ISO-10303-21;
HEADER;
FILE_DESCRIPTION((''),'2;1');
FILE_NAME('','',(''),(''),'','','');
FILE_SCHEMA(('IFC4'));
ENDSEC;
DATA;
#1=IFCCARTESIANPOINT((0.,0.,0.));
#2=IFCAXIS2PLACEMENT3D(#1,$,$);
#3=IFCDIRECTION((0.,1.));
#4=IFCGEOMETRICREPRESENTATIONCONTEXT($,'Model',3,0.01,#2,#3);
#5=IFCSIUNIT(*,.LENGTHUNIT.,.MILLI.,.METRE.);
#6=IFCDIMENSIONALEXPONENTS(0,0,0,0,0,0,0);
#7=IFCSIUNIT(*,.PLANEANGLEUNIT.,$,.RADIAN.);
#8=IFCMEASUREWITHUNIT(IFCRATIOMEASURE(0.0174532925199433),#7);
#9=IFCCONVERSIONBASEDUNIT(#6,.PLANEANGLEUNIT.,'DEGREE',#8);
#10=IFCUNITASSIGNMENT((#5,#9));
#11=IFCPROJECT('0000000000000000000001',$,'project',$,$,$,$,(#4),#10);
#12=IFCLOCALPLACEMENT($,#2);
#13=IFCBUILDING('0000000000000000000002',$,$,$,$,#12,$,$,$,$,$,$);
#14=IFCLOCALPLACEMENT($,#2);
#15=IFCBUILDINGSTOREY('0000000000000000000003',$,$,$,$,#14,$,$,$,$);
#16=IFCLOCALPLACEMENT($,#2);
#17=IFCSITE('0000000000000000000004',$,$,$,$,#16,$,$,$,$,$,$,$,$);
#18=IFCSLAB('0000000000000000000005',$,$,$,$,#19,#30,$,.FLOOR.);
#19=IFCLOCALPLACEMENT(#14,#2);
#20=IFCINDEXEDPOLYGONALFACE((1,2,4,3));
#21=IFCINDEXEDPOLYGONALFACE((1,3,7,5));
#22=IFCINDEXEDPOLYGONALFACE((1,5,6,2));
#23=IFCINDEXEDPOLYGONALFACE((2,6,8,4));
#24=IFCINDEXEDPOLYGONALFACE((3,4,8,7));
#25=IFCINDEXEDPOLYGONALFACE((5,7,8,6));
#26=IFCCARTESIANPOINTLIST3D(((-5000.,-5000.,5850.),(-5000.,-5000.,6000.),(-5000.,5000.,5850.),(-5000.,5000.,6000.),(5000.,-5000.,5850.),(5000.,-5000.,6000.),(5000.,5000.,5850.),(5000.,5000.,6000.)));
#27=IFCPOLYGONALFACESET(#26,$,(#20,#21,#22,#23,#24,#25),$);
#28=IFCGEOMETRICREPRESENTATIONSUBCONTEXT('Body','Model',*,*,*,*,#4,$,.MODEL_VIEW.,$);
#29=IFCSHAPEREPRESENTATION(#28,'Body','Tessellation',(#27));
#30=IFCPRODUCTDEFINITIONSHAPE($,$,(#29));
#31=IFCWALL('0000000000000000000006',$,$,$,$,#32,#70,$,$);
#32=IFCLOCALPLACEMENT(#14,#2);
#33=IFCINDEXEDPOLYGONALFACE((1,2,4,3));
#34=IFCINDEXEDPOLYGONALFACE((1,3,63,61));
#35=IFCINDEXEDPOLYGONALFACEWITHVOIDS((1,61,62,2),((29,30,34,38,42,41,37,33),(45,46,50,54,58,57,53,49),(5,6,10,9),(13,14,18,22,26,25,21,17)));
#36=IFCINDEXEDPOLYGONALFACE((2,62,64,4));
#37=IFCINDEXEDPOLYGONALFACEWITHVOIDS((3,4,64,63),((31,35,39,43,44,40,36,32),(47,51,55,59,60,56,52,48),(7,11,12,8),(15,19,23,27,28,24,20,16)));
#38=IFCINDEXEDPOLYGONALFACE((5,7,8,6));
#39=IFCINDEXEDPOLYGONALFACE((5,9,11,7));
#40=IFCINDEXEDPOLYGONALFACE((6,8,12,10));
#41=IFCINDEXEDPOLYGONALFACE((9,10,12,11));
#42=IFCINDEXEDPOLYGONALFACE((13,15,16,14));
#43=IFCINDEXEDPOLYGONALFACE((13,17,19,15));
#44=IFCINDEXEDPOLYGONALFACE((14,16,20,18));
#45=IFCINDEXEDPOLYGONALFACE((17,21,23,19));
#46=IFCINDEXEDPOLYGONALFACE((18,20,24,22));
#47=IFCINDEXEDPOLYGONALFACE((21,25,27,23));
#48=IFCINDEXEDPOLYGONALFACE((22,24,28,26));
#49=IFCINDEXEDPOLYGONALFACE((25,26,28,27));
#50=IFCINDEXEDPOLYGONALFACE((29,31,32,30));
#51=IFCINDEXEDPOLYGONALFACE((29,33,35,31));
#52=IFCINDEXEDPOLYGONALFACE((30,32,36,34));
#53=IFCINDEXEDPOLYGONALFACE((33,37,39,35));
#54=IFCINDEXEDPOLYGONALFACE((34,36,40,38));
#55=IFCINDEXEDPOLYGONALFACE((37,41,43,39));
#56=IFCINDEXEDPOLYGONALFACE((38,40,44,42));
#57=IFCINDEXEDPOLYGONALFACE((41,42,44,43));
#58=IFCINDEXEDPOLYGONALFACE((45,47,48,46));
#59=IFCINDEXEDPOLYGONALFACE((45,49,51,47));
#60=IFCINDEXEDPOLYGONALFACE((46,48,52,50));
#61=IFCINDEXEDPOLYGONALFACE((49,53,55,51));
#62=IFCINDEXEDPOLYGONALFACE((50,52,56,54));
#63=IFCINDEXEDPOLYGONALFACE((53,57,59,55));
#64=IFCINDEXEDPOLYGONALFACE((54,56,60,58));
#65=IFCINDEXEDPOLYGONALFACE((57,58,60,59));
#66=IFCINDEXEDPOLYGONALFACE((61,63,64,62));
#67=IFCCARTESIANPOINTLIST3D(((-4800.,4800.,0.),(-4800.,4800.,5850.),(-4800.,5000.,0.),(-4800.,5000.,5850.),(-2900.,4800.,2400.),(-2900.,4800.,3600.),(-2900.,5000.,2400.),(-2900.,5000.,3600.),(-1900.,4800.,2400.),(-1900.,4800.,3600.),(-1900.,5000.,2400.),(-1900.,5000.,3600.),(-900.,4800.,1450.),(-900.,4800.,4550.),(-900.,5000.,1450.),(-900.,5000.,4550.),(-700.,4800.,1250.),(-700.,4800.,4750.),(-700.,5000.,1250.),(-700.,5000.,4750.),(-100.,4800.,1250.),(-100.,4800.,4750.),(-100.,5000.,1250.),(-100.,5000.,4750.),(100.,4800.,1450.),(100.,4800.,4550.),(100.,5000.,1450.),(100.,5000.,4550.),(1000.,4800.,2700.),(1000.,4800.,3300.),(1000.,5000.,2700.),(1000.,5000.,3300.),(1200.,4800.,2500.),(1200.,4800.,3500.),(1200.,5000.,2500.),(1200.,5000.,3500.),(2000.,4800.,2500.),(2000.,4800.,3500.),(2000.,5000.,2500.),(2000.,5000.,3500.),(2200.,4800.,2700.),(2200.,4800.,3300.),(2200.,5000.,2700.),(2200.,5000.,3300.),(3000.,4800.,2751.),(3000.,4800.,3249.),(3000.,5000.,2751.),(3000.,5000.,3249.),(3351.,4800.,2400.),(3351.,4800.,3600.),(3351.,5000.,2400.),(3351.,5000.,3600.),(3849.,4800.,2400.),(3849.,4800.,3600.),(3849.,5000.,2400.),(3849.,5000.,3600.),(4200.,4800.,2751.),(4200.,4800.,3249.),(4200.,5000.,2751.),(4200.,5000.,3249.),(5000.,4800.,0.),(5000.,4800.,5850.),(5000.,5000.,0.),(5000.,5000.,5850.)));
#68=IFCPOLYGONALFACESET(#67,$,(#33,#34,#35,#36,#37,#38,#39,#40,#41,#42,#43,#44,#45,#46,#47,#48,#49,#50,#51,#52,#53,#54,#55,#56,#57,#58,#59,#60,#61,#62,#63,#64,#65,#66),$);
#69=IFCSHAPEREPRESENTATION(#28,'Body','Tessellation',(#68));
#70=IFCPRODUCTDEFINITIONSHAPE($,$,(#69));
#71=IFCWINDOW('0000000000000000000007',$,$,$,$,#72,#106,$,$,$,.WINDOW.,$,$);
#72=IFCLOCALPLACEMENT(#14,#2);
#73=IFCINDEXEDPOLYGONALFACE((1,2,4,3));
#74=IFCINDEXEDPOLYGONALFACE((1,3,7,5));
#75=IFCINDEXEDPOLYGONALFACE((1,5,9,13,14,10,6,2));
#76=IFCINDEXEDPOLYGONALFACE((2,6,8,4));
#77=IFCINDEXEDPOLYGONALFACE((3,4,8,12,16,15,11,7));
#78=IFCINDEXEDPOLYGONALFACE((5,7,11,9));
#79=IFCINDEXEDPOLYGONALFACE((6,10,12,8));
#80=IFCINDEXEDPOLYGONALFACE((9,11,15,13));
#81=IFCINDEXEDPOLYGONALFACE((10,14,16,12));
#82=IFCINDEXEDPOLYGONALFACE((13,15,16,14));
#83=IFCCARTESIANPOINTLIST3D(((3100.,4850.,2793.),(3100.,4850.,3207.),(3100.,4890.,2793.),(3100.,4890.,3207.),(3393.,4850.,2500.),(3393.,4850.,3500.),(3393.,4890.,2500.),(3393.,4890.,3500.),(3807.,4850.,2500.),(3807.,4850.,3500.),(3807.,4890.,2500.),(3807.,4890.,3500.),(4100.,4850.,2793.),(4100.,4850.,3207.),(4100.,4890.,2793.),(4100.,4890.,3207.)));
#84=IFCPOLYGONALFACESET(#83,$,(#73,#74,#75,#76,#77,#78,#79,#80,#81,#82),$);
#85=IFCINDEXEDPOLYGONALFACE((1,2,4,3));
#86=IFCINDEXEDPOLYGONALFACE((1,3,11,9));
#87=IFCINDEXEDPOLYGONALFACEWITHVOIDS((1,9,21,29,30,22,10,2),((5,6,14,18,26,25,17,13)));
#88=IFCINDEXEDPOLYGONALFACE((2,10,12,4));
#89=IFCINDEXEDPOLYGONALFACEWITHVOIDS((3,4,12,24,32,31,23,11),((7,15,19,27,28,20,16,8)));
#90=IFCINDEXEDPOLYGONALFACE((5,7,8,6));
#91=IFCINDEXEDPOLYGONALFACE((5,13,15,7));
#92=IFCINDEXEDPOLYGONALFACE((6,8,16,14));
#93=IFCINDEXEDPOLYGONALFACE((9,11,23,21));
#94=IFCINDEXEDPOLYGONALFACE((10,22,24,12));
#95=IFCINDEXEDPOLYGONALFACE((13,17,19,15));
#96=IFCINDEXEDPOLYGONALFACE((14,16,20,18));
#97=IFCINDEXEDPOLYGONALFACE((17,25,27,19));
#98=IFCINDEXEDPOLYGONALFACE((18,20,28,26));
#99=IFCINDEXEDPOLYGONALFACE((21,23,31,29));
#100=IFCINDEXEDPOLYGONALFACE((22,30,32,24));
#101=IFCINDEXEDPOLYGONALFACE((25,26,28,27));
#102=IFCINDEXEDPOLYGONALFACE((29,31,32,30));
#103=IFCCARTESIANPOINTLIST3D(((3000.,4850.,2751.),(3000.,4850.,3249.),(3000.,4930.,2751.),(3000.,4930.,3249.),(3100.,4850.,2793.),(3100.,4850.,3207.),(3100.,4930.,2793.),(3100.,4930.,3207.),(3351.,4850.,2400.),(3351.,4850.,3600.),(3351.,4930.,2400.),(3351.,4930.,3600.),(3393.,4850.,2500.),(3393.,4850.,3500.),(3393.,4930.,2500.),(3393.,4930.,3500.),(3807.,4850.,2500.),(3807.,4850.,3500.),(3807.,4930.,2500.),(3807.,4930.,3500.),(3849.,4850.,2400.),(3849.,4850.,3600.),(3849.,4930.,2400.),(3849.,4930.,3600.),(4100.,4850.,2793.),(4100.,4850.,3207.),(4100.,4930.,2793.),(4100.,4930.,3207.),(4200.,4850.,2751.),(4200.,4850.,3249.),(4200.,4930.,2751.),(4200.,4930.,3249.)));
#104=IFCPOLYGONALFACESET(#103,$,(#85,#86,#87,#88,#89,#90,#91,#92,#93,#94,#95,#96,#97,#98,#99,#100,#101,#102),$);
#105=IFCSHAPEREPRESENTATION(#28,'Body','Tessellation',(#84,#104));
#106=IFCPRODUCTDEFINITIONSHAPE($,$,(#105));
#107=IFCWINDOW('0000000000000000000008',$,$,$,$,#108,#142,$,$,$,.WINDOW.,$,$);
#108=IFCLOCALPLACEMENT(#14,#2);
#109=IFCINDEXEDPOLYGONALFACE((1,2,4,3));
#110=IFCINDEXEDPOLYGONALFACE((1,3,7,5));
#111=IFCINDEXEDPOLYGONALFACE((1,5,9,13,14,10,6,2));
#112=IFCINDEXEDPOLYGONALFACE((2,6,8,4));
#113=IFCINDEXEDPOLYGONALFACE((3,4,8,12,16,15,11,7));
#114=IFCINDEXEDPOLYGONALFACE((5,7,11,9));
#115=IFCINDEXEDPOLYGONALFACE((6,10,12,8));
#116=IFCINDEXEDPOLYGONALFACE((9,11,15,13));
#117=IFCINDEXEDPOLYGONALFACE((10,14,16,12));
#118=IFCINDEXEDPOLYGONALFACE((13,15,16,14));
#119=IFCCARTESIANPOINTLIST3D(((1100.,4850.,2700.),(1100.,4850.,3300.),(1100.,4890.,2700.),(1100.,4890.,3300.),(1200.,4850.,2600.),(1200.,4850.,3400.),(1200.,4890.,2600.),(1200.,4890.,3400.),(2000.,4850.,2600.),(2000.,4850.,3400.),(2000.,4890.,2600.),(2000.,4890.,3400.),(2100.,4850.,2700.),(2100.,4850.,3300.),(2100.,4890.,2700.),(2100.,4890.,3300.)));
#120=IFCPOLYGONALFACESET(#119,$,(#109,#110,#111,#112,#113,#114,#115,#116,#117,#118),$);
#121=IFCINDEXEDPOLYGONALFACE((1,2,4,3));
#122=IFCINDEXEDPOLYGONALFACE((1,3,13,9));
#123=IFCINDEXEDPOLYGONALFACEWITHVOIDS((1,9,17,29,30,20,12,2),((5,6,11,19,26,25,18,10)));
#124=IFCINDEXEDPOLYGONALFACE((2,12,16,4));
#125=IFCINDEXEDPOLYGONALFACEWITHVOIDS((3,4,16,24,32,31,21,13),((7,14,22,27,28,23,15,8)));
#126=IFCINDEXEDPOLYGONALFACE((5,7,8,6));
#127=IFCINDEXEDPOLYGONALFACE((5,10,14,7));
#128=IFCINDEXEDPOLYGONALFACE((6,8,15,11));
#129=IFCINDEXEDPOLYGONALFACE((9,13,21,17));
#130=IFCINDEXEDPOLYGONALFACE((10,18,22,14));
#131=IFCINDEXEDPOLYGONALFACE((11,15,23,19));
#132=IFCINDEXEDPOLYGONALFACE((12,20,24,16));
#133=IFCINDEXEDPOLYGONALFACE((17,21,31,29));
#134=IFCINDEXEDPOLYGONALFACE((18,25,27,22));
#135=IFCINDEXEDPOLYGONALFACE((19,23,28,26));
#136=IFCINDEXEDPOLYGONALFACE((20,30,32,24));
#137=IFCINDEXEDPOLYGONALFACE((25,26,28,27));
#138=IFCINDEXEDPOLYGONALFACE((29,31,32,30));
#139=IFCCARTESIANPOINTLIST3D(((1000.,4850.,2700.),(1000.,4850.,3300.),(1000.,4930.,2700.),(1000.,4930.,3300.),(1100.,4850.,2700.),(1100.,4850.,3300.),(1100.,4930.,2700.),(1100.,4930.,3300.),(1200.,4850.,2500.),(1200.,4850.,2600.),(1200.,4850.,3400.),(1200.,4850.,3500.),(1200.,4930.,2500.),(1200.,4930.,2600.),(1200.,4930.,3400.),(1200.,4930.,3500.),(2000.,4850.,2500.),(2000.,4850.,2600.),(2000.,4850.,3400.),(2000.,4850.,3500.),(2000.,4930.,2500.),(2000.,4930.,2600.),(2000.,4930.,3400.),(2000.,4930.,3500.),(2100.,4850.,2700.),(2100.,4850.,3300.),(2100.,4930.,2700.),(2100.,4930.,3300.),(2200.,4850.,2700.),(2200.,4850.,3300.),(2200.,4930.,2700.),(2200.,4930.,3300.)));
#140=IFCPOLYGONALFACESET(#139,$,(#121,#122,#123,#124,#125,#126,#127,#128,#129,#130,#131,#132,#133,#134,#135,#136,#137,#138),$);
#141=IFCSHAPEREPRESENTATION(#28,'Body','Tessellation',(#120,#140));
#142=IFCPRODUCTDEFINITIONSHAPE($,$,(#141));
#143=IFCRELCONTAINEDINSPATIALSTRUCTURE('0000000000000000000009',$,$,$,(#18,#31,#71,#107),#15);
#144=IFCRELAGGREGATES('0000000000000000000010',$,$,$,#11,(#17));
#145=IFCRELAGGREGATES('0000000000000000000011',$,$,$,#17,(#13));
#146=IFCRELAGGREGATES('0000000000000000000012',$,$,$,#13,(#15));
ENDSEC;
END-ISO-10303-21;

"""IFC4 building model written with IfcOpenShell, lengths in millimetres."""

from ifc_helpers import new_model, entity, si_unit, converted_unit, direction, frame, origin, origin_2d, place, context, subcontext, project, spatial, polyline, rectangle, outline, extrude, element, save


model = new_model("IFC4")

# Units and contexts
model_context = context("Model", 3, precision=0.01, world=origin(), true_north=direction((0.0, 1.0)))
body_context = subcontext(model_context, "Body", "Model", "MODEL_VIEW")
ifc_project = project(units=[si_unit("LENGTHUNIT", "METRE", prefix="MILLI"), converted_unit("PLANEANGLEUNIT", "DEGREE", entity("IfcRatioMeasure", 0.0174532925199433), si_unit("PLANEANGLEUNIT", "RADIAN"), dimensions=[0, 0, 0, 0, 0, 0, 0])], contexts=[model_context])

# Site, building, storey
site_placement = place(None, origin())
site = spatial("IfcSite", under=ifc_project, at=site_placement)
building_placement = place(None, origin())
building = spatial("IfcBuilding", under=site, at=building_placement)
storey_placement = place(None, origin())
storey = spatial("IfcBuildingStorey", under=building, at=storey_placement)

# Slab
slab_placement = place(storey_placement, frame((0.0, 0.0, 5850.0)))
element("IfcSlab", 1, at=slab_placement, inside=storey, PredefinedType="FLOOR", context=body_context, shape_type="SweptSolid", body=[
    extrude(rectangle(XDim=10000.0, YDim=10000.0, at=origin_2d()), origin(), (0.0, 0.0, 1.0), 150.0),
])

# Wall, openings
wall_1_placement = place(storey_placement, frame((100.0, 4900.0, 0.0), z_axis=(0.0, 0.0, 1.0), x_axis=(-1.0, 0.0, 0.0)))
wall_1 = element("IfcWall", 2, at=wall_1_placement, inside=storey, context=body_context, shape_type="SweptSolid", body=[
    extrude(rectangle(XDim=9800.0, YDim=200.0, at=origin_2d()), origin(), (0.0, 0.0, 1.0), 5850.0),
])
window_1_placement = place(wall_1_placement, frame((-3500.0, 50.0, 3000.0)))
opening_1_placement = place(window_1_placement, frame((0.0, 50.0, 0.0)))
element("IfcOpeningElement", 3, at=opening_1_placement, cuts=wall_1, context=body_context, shape_type="SweptSolid", body=[
    extrude(outline(polyline([(-600.0, -249.0), (-600.0, 249.0), (-249.0, 600.0), (249.0, 600.0), (600.0, 249.0), (600.0, -249.0), (249.0, -600.0), (-249.0, -600.0), (-600.0, -249.0)])), frame((0.0, 0.0, 0.0), z_axis=(0.0, -1.0, 0.0), x_axis=(1.0, 0.0, 0.0)), (0.0, 0.0, 1.0), 200.0),
])
window_2_placement = place(wall_1_placement, frame((-1500.0, 50.0, 3000.0)))
opening_2_placement = place(window_2_placement, frame((0.0, 50.0, 0.0)))
element("IfcOpeningElement", 4, at=opening_2_placement, cuts=wall_1, context=body_context, shape_type="SweptSolid", body=[
    extrude(outline(polyline([(-600.0, -300.0), (-600.0, 300.0), (-400.0, 500.0), (400.0, 500.0), (600.0, 300.0), (600.0, -300.0), (400.0, -500.0), (-400.0, -500.0), (-600.0, -300.0)])), frame((0.0, 0.0, 0.0), z_axis=(0.0, -1.0, 0.0), x_axis=(1.0, 0.0, 0.0)), (0.0, 0.0, 1.0), 200.0),
])
window_3_placement = place(wall_1_placement, frame((500.0, 50.0, 3000.0)))
opening_3_placement = place(window_3_placement, frame((0.0, 50.0, 0.0)))
element("IfcOpeningElement", 5, at=opening_3_placement, cuts=wall_1, context=body_context, shape_type="SweptSolid", body=[
    extrude(outline(polyline([(-500.0, -1550.0), (-500.0, 1550.0), (-300.0, 1750.0), (300.0, 1750.0), (500.0, 1550.0), (500.0, -1550.0), (300.0, -1750.0), (-300.0, -1750.0), (-500.0, -1550.0)])), frame((0.0, 0.0, 0.0), z_axis=(0.0, -1.0, 0.0), x_axis=(1.0, 0.0, 0.0)), (0.0, 0.0, 1.0), 200.0),
])
window_4_placement = place(wall_1_placement, frame((2500.0, 50.0, 3000.0)))
opening_4_placement = place(window_4_placement, frame((0.0, 50.0, 0.0)))
element("IfcOpeningElement", 6, at=opening_4_placement, cuts=wall_1, context=body_context, shape_type="SweptSolid", body=[
    extrude(outline(polyline([(-500.0, -600.0), (-500.0, 600.0), (-500.0, 600.0), (500.0, 600.0), (500.0, 600.0), (500.0, -600.0), (500.0, -600.0), (-500.0, -600.0), (-500.0, -600.0)])), frame((0.0, 0.0, 0.0), z_axis=(0.0, -1.0, 0.0), x_axis=(1.0, 0.0, 0.0)), (0.0, 0.0, 1.0), 200.0),
])

# Windows
cartesian_point_1 = entity("IfcCartesianPoint", [-500.0, -207.0])
shared_polyline_1 = entity("IfcPolyline", [cartesian_point_1, entity("IfcCartesianPoint", [-500.0, 207.0]), entity("IfcCartesianPoint", [-207.0, 500.0]), entity("IfcCartesianPoint", [207.0, 500.0]), entity("IfcCartesianPoint", [500.0, 207.0]), entity("IfcCartesianPoint", [500.0, -207.0]), entity("IfcCartesianPoint", [207.0, -500.0]), entity("IfcCartesianPoint", [-207.0, -500.0]), cartesian_point_1])
cartesian_point_2 = entity("IfcCartesianPoint", [-600.0, -249.0])
element("IfcWindow", 7, at=window_1_placement, inside=storey, PredefinedType="WINDOW", context=body_context, shape_type="SweptSolid", body=[
    entity("IfcExtrudedAreaSolid", entity("IfcArbitraryClosedProfileDef", "AREA", None, shared_polyline_1), entity("IfcAxis2Placement3D", entity("IfcCartesianPoint", [0.0, 0.0, 0.0]), entity("IfcDirection", [0.0, -1.0, 0.0]), entity("IfcDirection", [1.0, 0.0, 0.0])), entity("IfcDirection", [0.0, 0.0, 1.0]), 40.0),
    entity("IfcExtrudedAreaSolid", entity("IfcArbitraryProfileDefWithVoids", "AREA", None, entity("IfcPolyline", [cartesian_point_2, entity("IfcCartesianPoint", [-600.0, 249.0]), entity("IfcCartesianPoint", [-249.0, 600.0]), entity("IfcCartesianPoint", [249.0, 600.0]), entity("IfcCartesianPoint", [600.0, 249.0]), entity("IfcCartesianPoint", [600.0, -249.0]), entity("IfcCartesianPoint", [249.0, -600.0]), entity("IfcCartesianPoint", [-249.0, -600.0]), cartesian_point_2]), [shared_polyline_1]), entity("IfcAxis2Placement3D", entity("IfcCartesianPoint", [0.0, 0.0, 0.0]), entity("IfcDirection", [0.0, -1.0, 0.0]), entity("IfcDirection", [1.0, 0.0, 0.0])), entity("IfcDirection", [0.0, 0.0, 1.0]), 80.0),
])
cartesian_point_3 = entity("IfcCartesianPoint", [-500.0, -300.0])
shared_polyline_2 = entity("IfcPolyline", [cartesian_point_3, entity("IfcCartesianPoint", [-500.0, 300.0]), entity("IfcCartesianPoint", [-400.0, 400.0]), entity("IfcCartesianPoint", [400.0, 400.0]), entity("IfcCartesianPoint", [500.0, 300.0]), entity("IfcCartesianPoint", [500.0, -300.0]), entity("IfcCartesianPoint", [400.0, -400.0]), entity("IfcCartesianPoint", [-400.0, -400.0]), cartesian_point_3])
cartesian_point_4 = entity("IfcCartesianPoint", [-600.0, -300.0])
element("IfcWindow", 8, at=window_2_placement, inside=storey, PredefinedType="WINDOW", context=body_context, shape_type="SweptSolid", body=[
    entity("IfcExtrudedAreaSolid", entity("IfcArbitraryClosedProfileDef", "AREA", None, shared_polyline_2), entity("IfcAxis2Placement3D", entity("IfcCartesianPoint", [0.0, 0.0, 0.0]), entity("IfcDirection", [0.0, -1.0, 0.0]), entity("IfcDirection", [1.0, 0.0, 0.0])), entity("IfcDirection", [0.0, 0.0, 1.0]), 40.0),
    entity("IfcExtrudedAreaSolid", entity("IfcArbitraryProfileDefWithVoids", "AREA", None, entity("IfcPolyline", [cartesian_point_4, entity("IfcCartesianPoint", [-600.0, 300.0]), entity("IfcCartesianPoint", [-400.0, 500.0]), entity("IfcCartesianPoint", [400.0, 500.0]), entity("IfcCartesianPoint", [600.0, 300.0]), entity("IfcCartesianPoint", [600.0, -300.0]), entity("IfcCartesianPoint", [400.0, -500.0]), entity("IfcCartesianPoint", [-400.0, -500.0]), cartesian_point_4]), [shared_polyline_2]), entity("IfcAxis2Placement3D", entity("IfcCartesianPoint", [0.0, 0.0, 0.0]), entity("IfcDirection", [0.0, -1.0, 0.0]), entity("IfcDirection", [1.0, 0.0, 0.0])), entity("IfcDirection", [0.0, 0.0, 1.0]), 80.0),
])

save(model, "model.ifc")
